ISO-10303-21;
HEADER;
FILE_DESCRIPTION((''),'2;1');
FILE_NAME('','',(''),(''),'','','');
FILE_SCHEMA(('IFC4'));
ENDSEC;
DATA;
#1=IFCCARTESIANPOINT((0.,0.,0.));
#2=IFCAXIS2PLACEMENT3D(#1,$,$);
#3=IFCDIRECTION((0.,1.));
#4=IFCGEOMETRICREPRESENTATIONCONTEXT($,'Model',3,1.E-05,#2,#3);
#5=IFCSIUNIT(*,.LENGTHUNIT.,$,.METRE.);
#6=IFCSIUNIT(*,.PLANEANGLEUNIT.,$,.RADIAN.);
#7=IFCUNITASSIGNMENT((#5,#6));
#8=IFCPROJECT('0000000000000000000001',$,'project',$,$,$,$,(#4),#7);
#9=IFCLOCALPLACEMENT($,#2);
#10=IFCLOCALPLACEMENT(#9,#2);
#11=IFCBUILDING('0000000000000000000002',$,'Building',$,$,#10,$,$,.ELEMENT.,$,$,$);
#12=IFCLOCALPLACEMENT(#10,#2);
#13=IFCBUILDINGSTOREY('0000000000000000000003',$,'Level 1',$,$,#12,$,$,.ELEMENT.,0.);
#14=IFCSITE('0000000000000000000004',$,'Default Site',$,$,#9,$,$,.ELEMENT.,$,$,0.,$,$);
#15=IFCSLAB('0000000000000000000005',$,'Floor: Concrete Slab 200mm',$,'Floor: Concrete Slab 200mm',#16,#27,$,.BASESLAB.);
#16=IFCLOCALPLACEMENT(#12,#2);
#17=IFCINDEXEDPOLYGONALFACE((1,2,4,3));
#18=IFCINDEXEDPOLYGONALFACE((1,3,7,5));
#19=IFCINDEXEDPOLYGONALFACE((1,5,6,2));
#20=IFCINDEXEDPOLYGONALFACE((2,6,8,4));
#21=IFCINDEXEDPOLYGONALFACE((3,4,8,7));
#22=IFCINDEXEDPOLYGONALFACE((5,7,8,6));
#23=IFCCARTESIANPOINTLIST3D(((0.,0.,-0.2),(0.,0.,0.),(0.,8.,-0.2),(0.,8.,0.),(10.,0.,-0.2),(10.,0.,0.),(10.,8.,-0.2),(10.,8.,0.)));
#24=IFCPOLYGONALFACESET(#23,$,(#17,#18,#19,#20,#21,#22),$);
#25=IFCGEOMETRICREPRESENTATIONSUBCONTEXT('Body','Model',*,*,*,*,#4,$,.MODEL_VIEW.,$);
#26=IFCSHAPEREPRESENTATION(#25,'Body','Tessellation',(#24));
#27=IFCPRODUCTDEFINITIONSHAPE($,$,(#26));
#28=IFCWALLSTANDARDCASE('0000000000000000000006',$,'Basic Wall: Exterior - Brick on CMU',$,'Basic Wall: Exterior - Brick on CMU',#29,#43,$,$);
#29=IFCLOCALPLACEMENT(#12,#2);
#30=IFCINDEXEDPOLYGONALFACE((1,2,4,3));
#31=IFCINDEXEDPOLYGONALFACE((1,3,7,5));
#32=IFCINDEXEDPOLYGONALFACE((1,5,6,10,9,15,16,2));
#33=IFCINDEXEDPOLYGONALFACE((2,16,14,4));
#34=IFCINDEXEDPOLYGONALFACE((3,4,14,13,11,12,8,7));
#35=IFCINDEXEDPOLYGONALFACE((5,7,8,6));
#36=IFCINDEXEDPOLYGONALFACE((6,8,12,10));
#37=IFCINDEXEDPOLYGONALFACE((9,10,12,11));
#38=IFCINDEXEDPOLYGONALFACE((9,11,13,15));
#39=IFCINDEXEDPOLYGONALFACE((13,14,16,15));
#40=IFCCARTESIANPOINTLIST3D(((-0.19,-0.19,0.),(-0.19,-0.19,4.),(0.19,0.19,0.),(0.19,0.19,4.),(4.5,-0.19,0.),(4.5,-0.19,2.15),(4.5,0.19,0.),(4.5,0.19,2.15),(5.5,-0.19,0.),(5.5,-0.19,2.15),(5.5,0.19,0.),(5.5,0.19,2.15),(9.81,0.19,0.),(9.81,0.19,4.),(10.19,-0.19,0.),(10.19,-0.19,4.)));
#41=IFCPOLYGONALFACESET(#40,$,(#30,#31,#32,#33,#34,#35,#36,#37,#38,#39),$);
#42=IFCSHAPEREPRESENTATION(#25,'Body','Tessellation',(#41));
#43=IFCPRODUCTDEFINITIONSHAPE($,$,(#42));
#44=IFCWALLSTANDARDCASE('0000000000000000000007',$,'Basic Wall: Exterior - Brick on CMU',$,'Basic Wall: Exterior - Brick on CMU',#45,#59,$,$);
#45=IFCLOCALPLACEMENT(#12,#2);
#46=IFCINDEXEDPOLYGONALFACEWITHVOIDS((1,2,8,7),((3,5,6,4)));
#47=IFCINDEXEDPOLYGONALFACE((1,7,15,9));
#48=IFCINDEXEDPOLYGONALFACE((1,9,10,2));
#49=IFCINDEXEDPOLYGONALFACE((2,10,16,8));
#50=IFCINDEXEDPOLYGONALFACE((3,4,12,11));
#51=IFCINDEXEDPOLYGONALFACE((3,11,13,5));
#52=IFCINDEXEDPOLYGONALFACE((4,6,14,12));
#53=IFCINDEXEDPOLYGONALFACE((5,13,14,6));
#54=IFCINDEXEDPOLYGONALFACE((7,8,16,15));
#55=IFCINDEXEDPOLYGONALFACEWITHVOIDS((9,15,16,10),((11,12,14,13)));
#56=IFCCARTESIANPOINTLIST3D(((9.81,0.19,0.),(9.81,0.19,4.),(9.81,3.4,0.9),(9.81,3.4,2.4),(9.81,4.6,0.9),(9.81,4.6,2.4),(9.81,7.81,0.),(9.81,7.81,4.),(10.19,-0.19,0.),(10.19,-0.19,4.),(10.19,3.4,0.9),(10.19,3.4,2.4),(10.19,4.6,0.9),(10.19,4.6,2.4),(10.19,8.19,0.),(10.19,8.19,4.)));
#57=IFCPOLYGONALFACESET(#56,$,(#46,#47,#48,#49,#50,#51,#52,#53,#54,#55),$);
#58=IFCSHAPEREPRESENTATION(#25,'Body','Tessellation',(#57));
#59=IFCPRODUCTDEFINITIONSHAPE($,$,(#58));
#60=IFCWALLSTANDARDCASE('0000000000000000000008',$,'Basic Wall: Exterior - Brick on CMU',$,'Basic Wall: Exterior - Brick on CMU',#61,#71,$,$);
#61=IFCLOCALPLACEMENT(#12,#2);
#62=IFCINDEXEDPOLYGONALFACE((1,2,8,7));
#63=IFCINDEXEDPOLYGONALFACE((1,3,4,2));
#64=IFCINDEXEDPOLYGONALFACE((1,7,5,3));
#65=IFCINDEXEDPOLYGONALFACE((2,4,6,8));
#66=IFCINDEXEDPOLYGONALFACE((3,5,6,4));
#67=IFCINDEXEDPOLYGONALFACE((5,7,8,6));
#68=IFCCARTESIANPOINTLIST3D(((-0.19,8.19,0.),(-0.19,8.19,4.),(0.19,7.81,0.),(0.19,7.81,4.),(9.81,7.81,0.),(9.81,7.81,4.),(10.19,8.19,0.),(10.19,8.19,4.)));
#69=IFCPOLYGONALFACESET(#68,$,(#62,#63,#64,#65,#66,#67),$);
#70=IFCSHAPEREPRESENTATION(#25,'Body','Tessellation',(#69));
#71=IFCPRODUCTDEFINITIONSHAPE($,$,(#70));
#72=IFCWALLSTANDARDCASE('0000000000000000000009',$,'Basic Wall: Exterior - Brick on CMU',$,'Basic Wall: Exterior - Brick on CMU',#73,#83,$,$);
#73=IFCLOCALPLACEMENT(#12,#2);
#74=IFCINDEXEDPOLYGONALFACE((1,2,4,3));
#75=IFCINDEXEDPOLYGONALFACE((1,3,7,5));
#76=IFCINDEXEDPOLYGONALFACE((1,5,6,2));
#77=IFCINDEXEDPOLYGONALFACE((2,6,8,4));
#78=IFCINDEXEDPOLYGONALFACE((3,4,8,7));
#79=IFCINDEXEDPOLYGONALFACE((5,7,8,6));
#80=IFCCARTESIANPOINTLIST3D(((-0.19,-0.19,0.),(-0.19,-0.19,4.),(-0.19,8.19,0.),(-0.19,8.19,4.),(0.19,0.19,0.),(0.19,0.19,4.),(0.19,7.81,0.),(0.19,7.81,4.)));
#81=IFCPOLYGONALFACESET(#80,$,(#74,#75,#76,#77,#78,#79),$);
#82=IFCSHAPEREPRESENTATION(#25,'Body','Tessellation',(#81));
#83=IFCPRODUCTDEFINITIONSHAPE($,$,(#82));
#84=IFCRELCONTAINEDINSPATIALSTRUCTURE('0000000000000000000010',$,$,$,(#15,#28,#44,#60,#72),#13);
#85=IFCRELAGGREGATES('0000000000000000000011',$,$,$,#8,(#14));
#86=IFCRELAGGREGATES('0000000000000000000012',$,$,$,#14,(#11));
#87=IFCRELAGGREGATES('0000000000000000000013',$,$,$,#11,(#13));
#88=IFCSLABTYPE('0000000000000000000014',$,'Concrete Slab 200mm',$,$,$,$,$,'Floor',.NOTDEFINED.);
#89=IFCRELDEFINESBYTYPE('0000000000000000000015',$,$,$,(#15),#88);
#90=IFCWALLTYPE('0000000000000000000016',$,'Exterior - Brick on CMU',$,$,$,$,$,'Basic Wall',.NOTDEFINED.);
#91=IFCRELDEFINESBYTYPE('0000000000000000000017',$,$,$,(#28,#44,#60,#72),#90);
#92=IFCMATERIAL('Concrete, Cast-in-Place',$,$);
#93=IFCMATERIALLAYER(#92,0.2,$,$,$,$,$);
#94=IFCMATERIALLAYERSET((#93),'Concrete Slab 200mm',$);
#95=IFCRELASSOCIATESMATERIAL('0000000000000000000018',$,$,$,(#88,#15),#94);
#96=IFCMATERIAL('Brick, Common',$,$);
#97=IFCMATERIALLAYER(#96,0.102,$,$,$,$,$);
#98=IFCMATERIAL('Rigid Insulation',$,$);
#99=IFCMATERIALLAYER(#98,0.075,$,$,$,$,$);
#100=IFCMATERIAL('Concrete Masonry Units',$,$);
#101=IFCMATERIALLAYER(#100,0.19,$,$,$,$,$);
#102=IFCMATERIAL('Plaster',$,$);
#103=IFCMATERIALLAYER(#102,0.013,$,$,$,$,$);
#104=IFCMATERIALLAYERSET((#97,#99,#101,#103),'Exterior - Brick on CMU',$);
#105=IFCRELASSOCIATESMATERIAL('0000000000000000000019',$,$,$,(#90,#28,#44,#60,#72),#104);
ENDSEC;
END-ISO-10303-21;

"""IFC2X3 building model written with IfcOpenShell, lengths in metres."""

from ifc_helpers import new_model, si_unit, direction, frame, origin, origin_2d, place, context, subcontext, project, spatial, polyline, rectangle, outline, extrude, material, layer, layer_set, layer_usage, type_object, element, save


model = new_model("IFC2X3")

# Units and contexts
model_context = context("Model", 3, precision=1e-05, world=origin(), true_north=direction((0.0, 1.0)))
body_context = subcontext(model_context, "Body", "Model", "MODEL_VIEW")
ifc_project = project(units=[si_unit("LENGTHUNIT", "METRE"), si_unit("PLANEANGLEUNIT", "RADIAN")], contexts=[model_context])

# Site, building, storey
site_placement = place(None, origin())
site = spatial("IfcSite", under=ifc_project, at=site_placement, Name="Default Site", CompositionType="ELEMENT", RefElevation=0.0)
building_placement = place(site_placement, origin())
building = spatial("IfcBuilding", under=site, at=building_placement, Name="Building", CompositionType="ELEMENT")
storey_placement = place(building_placement, origin())
storey = spatial("IfcBuildingStorey", under=building, at=storey_placement, Name="Level 1", CompositionType="ELEMENT", Elevation=0.0)

# Slab
ifc_material_1 = material(Name="Concrete, Cast-in-Place")
ifc_layer_1 = layer(ifc_material_1, 0.2)
ifc_layer_set_1 = layer_set([ifc_layer_1], Name="Concrete Slab 200mm")
ifc_layer_usage_1 = layer_usage(ifc_layer_set_1, "AXIS3", "NEGATIVE", 0.0)
slab_type = type_object("IfcSlabType", Name="Concrete Slab 200mm", ElementType="Floor", PredefinedType="NOTDEFINED", material=ifc_layer_set_1)
slab_placement = place(storey_placement, origin())
element("IfcSlab", 1, at=slab_placement, inside=storey, type_object=slab_type, material=ifc_layer_usage_1, Name="Floor: Concrete Slab 200mm", ObjectType="Floor: Concrete Slab 200mm", PredefinedType="BASESLAB", context=body_context, shape_type="SweptSolid", body=[
    extrude(outline(polyline([(0.0, 0.0), (10.0, 0.0), (10.0, 8.0), (0.0, 8.0), (0.0, 0.0)])), frame((0.0, 0.0, -0.2)), (0.0, 0.0, 1.0), 0.2),
])

# Walls, openings
ifc_material_2 = material(Name="Brick, Common")
ifc_layer_2 = layer(ifc_material_2, 0.102)
ifc_material_3 = material(Name="Rigid Insulation")
ifc_layer_3 = layer(ifc_material_3, 0.075)
ifc_material_4 = material(Name="Concrete Masonry Units")
ifc_layer_4 = layer(ifc_material_4, 0.19)
ifc_material_5 = material(Name="Plaster")
ifc_layer_5 = layer(ifc_material_5, 0.013)
ifc_layer_set_2 = layer_set([ifc_layer_2, ifc_layer_3, ifc_layer_4, ifc_layer_5], Name="Exterior - Brick on CMU")
ifc_layer_usage_2 = layer_usage(ifc_layer_set_2, "AXIS2", "NEGATIVE", 0.19)
wall_type = type_object("IfcWallType", Name="Exterior - Brick on CMU", ElementType="Basic Wall", PredefinedType="NOTDEFINED", material=ifc_layer_set_2)
wall_1_placement = place(storey_placement, origin())
wall_1 = element("IfcWallStandardCase", 2, at=wall_1_placement, inside=storey, type_object=wall_type, material=ifc_layer_usage_2, Name="Basic Wall: Exterior - Brick on CMU", ObjectType="Basic Wall: Exterior - Brick on CMU", context=body_context, shape_type="SweptSolid", body=[
    extrude(outline(polyline([(10.19, -0.19), (9.81, 0.19), (0.19, 0.19), (-0.19, -0.19), (10.19, -0.19)])), origin(), (0.0, 0.0, 1.0), 4.0),
])
opening_1_placement = place(wall_1_placement, frame((5.0, 0.0, 0.0)))
element("IfcOpeningElement", 3, at=opening_1_placement, cuts=wall_1, ObjectType="Opening", context=body_context, shape_type="SweptSolid", body=[
    extrude(rectangle(XDim=1.0, YDim=0.4, at=origin_2d()), origin(), (0.0, 0.0, 1.0), 2.15),
])
wall_2_placement = place(storey_placement, frame((10.0, 0.0, 0.0), z_axis=(0.0, 0.0, 1.0), x_axis=(0.0, 1.0, 0.0)))
wall_2 = element("IfcWallStandardCase", 4, at=wall_2_placement, inside=storey, type_object=wall_type, material=ifc_layer_usage_2, Name="Basic Wall: Exterior - Brick on CMU", ObjectType="Basic Wall: Exterior - Brick on CMU", context=body_context, shape_type="SweptSolid", body=[
    extrude(outline(polyline([(8.19, -0.19), (7.81, 0.19), (0.19, 0.19), (-0.19, -0.19), (8.19, -0.19)])), origin(), (0.0, 0.0, 1.0), 4.0),
])
opening_2_placement = place(wall_2_placement, frame((4.0, 0.0, 0.9)))
element("IfcOpeningElement", 5, at=opening_2_placement, cuts=wall_2, ObjectType="Opening", context=body_context, shape_type="SweptSolid", body=[
    extrude(rectangle(XDim=1.2, YDim=0.4, at=origin_2d()), origin(), (0.0, 0.0, 1.0), 1.5),
])

# Walls
wall_3_placement = place(storey_placement, frame((10.0, 8.0, 0.0), z_axis=(0.0, 0.0, 1.0), x_axis=(-1.0, 0.0, 0.0)))
element("IfcWallStandardCase", 6, at=wall_3_placement, inside=storey, type_object=wall_type, material=ifc_layer_usage_2, Name="Basic Wall: Exterior - Brick on CMU", ObjectType="Basic Wall: Exterior - Brick on CMU", context=body_context, shape_type="SweptSolid", body=[
    extrude(outline(polyline([(10.19, -0.19), (9.81, 0.19), (0.19, 0.19), (-0.19, -0.19), (10.19, -0.19)])), origin(), (0.0, 0.0, 1.0), 4.0),
])
wall_4_placement = place(storey_placement, frame((0.0, 8.0, 0.0), z_axis=(0.0, 0.0, 1.0), x_axis=(0.0, -1.0, 0.0)))
element("IfcWallStandardCase", 7, at=wall_4_placement, inside=storey, type_object=wall_type, material=ifc_layer_usage_2, Name="Basic Wall: Exterior - Brick on CMU", ObjectType="Basic Wall: Exterior - Brick on CMU", context=body_context, shape_type="SweptSolid", body=[
    extrude(outline(polyline([(8.19, -0.19), (7.81, 0.19), (0.19, 0.19), (-0.19, -0.19), (8.19, -0.19)])), origin(), (0.0, 0.0, 1.0), 4.0),
])

save(model, "model.ifc")
